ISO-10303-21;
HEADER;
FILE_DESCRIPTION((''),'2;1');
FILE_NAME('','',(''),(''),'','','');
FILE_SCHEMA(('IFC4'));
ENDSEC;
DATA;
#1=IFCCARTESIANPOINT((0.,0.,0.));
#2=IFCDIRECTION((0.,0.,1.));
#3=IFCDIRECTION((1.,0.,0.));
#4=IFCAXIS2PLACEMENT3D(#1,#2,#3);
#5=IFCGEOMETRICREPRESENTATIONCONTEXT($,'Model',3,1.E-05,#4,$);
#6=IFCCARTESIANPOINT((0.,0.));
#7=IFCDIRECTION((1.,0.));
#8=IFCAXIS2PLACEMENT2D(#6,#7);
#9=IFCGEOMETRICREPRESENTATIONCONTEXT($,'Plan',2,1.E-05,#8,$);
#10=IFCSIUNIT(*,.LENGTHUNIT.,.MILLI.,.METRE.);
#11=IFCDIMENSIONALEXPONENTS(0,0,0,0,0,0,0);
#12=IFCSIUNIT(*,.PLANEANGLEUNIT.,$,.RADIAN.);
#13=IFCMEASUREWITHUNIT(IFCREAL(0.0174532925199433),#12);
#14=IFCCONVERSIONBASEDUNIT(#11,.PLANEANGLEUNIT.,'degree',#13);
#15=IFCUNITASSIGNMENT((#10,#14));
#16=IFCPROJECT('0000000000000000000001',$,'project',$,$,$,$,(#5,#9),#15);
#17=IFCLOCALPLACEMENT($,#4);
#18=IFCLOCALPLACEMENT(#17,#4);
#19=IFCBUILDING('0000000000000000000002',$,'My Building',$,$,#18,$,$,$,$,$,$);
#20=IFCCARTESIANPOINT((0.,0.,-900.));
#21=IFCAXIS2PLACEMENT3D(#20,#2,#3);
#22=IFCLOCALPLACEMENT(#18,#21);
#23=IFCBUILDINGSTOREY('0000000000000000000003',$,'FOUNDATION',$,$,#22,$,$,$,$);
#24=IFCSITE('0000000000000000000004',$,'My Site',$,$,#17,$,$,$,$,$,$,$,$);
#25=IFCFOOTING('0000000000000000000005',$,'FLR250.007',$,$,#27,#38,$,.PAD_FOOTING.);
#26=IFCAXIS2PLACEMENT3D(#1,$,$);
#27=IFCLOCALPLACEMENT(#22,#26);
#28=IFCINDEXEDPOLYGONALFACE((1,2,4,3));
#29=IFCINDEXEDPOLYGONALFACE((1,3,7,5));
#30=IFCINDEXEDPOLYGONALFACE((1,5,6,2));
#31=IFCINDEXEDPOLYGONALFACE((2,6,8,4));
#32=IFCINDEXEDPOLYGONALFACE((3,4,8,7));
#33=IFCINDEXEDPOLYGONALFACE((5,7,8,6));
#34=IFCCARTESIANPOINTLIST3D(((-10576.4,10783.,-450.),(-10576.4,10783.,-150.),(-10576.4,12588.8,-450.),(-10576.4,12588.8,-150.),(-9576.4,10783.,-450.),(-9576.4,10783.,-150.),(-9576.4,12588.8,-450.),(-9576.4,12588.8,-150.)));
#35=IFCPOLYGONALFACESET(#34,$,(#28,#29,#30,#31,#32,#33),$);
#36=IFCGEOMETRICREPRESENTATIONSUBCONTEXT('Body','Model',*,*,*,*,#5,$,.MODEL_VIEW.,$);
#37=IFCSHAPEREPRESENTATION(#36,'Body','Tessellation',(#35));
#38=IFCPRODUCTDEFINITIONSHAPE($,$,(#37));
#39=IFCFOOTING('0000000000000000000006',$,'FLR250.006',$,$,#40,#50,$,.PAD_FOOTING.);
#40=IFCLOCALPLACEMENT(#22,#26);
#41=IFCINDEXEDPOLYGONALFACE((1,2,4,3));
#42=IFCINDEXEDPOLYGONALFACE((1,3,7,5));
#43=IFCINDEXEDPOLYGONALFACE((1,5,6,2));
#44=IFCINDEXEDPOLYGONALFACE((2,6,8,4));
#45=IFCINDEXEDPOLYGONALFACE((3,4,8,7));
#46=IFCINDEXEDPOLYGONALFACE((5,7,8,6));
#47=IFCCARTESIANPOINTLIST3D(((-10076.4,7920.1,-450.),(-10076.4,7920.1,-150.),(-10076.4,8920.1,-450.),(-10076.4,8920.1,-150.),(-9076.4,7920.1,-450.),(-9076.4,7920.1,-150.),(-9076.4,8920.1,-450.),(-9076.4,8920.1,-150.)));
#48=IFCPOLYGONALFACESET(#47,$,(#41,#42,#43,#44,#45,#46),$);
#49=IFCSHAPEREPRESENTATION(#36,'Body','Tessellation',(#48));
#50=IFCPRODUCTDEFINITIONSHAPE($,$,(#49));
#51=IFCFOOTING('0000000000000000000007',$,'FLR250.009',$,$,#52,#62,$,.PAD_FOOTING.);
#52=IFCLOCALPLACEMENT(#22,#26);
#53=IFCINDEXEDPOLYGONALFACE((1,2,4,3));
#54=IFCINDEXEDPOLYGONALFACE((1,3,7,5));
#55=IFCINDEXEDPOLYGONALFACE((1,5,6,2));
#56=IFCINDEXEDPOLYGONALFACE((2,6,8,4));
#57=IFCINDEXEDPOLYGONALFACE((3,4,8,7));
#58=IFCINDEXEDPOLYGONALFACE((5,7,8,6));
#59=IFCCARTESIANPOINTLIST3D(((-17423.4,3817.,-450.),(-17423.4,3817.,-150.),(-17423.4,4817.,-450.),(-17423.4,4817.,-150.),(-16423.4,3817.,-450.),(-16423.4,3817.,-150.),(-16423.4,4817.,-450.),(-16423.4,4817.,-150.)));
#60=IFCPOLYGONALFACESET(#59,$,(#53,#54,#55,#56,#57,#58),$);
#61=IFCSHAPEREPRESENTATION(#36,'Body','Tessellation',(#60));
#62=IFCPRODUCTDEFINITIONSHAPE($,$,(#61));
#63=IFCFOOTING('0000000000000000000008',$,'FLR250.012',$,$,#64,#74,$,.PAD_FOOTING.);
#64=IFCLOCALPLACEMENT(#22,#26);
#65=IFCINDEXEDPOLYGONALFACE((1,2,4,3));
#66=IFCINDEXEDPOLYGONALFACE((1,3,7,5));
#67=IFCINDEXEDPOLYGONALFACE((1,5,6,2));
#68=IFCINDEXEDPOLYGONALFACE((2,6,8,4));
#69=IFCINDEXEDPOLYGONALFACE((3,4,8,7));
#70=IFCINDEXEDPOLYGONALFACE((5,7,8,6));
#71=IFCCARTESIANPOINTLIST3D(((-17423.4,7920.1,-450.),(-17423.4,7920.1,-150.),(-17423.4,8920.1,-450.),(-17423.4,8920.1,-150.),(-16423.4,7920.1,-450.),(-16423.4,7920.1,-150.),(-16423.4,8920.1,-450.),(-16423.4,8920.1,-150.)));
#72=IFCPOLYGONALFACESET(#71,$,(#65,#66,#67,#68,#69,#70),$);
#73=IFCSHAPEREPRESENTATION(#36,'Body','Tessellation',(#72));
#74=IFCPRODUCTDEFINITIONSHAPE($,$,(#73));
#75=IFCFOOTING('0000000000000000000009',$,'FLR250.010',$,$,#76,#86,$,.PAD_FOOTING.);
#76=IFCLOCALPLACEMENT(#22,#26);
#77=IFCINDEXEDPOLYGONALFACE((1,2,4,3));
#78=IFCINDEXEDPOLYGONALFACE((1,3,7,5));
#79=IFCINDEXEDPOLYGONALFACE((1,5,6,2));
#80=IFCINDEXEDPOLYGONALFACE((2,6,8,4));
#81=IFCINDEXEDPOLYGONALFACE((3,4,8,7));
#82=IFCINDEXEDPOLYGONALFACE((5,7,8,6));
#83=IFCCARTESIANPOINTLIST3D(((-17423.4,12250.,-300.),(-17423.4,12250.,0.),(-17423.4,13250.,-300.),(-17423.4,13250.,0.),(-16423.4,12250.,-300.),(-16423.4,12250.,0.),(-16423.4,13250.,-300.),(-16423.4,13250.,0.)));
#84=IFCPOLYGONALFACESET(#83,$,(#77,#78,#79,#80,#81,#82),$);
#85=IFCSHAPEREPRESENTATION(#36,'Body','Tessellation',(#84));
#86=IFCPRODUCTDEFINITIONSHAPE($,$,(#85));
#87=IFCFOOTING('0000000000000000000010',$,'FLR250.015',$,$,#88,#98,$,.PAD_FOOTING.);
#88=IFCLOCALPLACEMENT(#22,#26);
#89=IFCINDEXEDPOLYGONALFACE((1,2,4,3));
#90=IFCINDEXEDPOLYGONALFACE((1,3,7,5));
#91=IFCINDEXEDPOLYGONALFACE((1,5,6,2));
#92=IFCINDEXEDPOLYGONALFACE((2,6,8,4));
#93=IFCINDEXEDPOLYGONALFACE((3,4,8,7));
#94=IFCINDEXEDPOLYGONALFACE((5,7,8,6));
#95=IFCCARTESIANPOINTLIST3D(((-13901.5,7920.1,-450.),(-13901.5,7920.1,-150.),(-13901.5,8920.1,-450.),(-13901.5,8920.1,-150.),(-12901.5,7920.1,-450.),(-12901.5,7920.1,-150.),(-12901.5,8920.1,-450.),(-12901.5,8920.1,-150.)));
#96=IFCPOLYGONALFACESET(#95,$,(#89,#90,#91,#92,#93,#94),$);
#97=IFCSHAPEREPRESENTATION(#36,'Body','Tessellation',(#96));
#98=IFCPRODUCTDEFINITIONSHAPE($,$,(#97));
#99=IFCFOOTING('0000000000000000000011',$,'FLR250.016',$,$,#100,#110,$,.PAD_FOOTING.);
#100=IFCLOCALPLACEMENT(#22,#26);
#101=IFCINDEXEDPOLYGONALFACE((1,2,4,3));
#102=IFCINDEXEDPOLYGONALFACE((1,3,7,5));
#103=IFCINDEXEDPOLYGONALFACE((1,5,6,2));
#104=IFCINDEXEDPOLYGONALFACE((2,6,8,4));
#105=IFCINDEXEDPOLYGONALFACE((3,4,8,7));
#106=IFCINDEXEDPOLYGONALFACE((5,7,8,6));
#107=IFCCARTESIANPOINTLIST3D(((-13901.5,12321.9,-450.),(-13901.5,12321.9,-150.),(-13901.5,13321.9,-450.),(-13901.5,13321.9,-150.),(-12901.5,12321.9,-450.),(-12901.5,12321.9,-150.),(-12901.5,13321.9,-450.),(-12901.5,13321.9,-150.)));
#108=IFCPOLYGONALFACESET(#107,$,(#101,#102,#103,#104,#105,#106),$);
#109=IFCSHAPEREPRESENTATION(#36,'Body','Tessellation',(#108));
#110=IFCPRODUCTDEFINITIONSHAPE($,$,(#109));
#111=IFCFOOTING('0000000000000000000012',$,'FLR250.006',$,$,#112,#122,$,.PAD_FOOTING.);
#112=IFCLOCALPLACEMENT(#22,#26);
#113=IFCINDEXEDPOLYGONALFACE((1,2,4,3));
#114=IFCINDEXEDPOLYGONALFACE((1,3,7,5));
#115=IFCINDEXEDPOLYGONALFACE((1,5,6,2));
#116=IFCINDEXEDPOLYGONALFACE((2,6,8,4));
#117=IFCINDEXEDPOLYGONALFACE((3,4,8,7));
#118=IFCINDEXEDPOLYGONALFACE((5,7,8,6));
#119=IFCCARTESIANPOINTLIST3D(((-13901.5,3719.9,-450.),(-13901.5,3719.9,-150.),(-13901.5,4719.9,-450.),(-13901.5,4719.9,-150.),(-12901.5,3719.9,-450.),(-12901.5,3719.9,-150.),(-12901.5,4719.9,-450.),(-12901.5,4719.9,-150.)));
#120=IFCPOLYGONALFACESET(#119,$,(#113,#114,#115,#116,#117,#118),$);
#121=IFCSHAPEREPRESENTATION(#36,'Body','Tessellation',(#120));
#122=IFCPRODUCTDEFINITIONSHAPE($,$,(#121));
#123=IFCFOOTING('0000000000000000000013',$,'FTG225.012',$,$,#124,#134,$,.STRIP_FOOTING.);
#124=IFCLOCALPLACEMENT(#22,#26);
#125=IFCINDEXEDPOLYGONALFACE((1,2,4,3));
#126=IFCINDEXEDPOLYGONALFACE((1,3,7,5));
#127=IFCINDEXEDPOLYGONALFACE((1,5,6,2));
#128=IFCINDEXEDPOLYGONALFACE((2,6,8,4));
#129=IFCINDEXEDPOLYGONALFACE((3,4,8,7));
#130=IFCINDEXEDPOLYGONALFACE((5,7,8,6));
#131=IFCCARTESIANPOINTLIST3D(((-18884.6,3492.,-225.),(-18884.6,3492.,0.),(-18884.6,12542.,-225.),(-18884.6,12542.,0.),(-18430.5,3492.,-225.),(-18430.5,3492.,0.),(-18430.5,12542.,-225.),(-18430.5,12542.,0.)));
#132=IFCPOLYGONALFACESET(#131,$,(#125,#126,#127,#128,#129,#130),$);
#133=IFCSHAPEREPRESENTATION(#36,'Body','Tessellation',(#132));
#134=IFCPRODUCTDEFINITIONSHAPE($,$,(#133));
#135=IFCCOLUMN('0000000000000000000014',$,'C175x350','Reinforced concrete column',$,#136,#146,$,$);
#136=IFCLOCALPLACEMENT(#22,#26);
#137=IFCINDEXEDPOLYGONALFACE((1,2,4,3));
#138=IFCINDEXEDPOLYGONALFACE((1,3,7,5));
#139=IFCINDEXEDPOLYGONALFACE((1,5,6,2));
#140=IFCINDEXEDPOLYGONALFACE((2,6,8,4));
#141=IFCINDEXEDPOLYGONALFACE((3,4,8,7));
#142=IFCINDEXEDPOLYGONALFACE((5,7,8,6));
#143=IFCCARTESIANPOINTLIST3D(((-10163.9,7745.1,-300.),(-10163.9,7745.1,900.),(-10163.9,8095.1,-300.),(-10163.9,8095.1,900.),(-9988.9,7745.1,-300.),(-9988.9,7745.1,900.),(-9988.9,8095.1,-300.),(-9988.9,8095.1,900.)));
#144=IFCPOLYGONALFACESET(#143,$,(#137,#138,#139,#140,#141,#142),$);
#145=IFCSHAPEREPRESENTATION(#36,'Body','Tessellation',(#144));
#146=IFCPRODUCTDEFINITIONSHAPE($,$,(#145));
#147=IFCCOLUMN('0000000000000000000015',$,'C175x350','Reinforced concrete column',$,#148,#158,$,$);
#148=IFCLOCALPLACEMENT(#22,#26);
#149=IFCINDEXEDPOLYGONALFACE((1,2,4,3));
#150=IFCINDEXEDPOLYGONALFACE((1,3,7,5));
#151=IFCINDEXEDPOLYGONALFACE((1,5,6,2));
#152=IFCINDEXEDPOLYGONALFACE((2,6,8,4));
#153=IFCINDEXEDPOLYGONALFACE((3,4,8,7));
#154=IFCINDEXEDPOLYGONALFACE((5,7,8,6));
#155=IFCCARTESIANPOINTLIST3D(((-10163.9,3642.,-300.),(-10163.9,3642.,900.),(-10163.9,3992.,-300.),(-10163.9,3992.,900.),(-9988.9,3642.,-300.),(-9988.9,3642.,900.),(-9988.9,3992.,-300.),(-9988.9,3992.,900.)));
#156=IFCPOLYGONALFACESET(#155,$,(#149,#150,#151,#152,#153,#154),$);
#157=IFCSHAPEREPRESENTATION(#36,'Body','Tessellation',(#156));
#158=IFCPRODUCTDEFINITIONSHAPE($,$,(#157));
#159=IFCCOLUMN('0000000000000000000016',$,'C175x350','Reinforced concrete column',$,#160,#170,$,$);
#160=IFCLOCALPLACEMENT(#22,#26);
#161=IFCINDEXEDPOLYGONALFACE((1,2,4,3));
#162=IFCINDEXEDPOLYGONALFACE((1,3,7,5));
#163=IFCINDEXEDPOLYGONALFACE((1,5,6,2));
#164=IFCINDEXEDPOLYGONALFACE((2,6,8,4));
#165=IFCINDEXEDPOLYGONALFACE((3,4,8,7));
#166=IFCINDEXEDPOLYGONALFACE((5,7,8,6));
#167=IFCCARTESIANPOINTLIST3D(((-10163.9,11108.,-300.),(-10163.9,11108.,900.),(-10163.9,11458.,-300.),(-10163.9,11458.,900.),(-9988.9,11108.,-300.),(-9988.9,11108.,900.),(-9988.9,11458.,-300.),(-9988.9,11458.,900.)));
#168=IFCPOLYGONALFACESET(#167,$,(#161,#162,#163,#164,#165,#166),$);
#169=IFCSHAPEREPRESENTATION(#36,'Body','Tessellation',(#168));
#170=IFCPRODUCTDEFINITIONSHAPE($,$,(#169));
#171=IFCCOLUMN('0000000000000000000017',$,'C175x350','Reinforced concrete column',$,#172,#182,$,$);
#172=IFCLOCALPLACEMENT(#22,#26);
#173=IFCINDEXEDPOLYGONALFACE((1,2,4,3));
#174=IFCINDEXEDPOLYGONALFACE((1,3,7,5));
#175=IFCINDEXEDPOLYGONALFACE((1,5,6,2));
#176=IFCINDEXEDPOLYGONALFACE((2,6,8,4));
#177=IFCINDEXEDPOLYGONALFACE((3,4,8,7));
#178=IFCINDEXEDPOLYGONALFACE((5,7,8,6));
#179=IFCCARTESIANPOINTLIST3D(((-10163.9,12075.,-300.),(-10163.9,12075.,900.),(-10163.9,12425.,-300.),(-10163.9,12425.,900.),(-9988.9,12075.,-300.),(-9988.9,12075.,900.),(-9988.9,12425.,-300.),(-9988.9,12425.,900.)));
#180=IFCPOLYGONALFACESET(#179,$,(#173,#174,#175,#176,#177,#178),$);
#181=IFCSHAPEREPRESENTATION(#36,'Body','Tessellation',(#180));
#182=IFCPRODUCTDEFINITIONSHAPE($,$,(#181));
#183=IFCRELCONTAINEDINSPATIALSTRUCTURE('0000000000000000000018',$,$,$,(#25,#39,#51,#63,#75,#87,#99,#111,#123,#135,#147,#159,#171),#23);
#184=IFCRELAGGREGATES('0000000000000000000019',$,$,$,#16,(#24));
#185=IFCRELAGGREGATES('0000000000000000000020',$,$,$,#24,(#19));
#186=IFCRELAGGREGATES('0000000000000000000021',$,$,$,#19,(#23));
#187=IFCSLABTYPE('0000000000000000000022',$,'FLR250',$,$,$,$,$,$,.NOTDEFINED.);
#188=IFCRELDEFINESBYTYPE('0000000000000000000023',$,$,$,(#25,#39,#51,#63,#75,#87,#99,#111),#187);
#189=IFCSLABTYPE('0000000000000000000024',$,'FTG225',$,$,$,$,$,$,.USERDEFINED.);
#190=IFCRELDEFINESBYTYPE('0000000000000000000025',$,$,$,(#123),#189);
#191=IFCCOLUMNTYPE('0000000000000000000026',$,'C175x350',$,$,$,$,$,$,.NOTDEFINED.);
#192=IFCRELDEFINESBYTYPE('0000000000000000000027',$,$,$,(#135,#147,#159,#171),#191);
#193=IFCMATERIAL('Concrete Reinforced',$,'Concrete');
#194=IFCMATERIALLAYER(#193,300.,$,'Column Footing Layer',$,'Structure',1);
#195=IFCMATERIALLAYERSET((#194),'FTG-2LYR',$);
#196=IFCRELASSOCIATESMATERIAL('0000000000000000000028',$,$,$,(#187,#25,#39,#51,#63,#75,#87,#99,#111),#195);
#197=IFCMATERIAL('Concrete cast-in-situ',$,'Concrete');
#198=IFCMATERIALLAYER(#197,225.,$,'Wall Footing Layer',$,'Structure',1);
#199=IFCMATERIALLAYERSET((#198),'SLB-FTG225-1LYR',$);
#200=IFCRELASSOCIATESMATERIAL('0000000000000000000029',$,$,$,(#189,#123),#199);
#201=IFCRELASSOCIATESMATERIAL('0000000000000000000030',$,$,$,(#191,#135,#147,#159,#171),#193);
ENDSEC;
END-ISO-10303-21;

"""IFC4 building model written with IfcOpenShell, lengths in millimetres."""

from ifc_helpers import new_model, entity, si_unit, converted_unit, frame, origin_with_axes, origin_2d_with_axis, place, context, subcontext, project, spatial, line, indexed_curve, rectangle, outline, extrude, material, layer, layer_set, layer_usage, material_profile, profile_set, profile_usage, type_object, element, save


model = new_model("IFC4")

# Units and contexts
model_context = context("Model", 3, precision=1e-05, world=origin_with_axes())
plan_context = context("Plan", 2, precision=1e-05, world=origin_2d_with_axis())
body_context = subcontext(model_context, "Body", "Model", "MODEL_VIEW")
ifc_project = project(units=[si_unit("LENGTHUNIT", "METRE", prefix="MILLI"), converted_unit("PLANEANGLEUNIT", "degree", entity("IfcReal", 0.0174532925199433), si_unit("PLANEANGLEUNIT", "RADIAN"), dimensions=[0, 0, 0, 0, 0, 0, 0])], contexts=[model_context, plan_context])

# Site, building, storey
site_placement = place(None, origin_with_axes())
site = spatial("IfcSite", under=ifc_project, at=site_placement, Name="My Site")
building_placement = place(site_placement, origin_with_axes())
building = spatial("IfcBuilding", under=site, at=building_placement, Name="My Building")
storey_placement = place(building_placement, frame((0.0, 0.0, -900.0), z_axis=(0.0, 0.0, 1.0), x_axis=(1.0, 0.0, 0.0)))
storey = spatial("IfcBuildingStorey", under=building, at=storey_placement, Name="FOUNDATION")

# Footings
ifc_material_1 = material(Name="Concrete Reinforced", Category="Concrete")
ifc_layer_1 = layer(ifc_material_1, 300.0, Name="Column Footing Layer", Category="Structure", Priority=1)
ifc_layer_set_1 = layer_set([ifc_layer_1], Name="FTG-2LYR")
ifc_layer_usage_1 = layer_usage(ifc_layer_set_1, "AXIS3", "POSITIVE", 0.0)
slab_type_1 = type_object("IfcSlabType", Name="FLR250", PredefinedType="NOTDEFINED", material=ifc_layer_set_1)
footing_1_placement = place(storey_placement, frame((-10076.4, 11283.0, -450.0), z_axis=(0.0, 0.0, 1.0), x_axis=(1.0, 0.0, 0.0)))
element("IfcFooting", 1, at=footing_1_placement, inside=storey, type_object=slab_type_1, material=ifc_layer_usage_1, Name="FLR250.007", PredefinedType="PAD_FOOTING", context=body_context, shape_type="SweptSolid", body=[
    extrude(outline(indexed_curve([(500.0, 1305.8), (500.0, -500.0), (-500.0, -500.0), (-500.0, 1305.8)], segments=[line(3, 2), line(2, 1), line(1, 4), line(4, 3)], self_intersect=False)), None, (0.0, 0.0, 1.0), 300.0),
])
ifc_layer_usage_2 = layer_usage(ifc_layer_set_1, "AXIS3", "POSITIVE", 0.0)
footing_2_placement = place(storey_placement, frame((-10076.4, 7920.1, -450.0), z_axis=(0.0, 0.0, 1.0), x_axis=(1.0, 0.0, 0.0)))
element("IfcFooting", 2, at=footing_2_placement, inside=storey, type_object=slab_type_1, material=ifc_layer_usage_2, Name="FLR250.006", PredefinedType="PAD_FOOTING", context=body_context, shape_type="SweptSolid", body=[
    extrude(outline(indexed_curve([(0.0, 0.0), (1000.0, 0.0), (1000.0, 1000.0), (0.0, 1000.0), (0.0, 0.0)])), None, (0.0, 0.0, 1.0), 300.0),
])
ifc_layer_usage_3 = layer_usage(ifc_layer_set_1, "AXIS3", "POSITIVE", 0.0)
footing_3_placement = place(storey_placement, frame((-17423.4, 3817.0, -450.0), z_axis=(0.0, 0.0, 1.0), x_axis=(1.0, 0.0, 0.0)))
element("IfcFooting", 3, at=footing_3_placement, inside=storey, type_object=slab_type_1, material=ifc_layer_usage_3, Name="FLR250.009", PredefinedType="PAD_FOOTING", context=body_context, shape_type="SweptSolid", body=[
    extrude(outline(indexed_curve([(0.0, 0.0), (1000.0, 0.0), (1000.0, 1000.0), (0.0, 1000.0), (0.0, 0.0)])), None, (0.0, 0.0, 1.0), 300.0),
])
ifc_layer_usage_4 = layer_usage(ifc_layer_set_1, "AXIS3", "POSITIVE", 0.0)
footing_4_placement = place(storey_placement, frame((-17423.4, 7920.1, -450.0), z_axis=(0.0, 0.0, 1.0), x_axis=(1.0, 0.0, 0.0)))
element("IfcFooting", 4, at=footing_4_placement, inside=storey, type_object=slab_type_1, material=ifc_layer_usage_4, Name="FLR250.012", PredefinedType="PAD_FOOTING", context=body_context, shape_type="SweptSolid", body=[
    extrude(outline(indexed_curve([(0.0, 0.0), (1000.0, 0.0), (1000.0, 1000.0), (0.0, 1000.0), (0.0, 0.0)])), None, (0.0, 0.0, 1.0), 300.0),
])
ifc_layer_usage_5 = layer_usage(ifc_layer_set_1, "AXIS3", "POSITIVE", 0.0)
footing_5_placement = place(storey_placement, frame((-17423.4, 12250.0, -300.0), z_axis=(0.0, 0.0, 1.0), x_axis=(1.0, 0.0, 0.0)))
element("IfcFooting", 5, at=footing_5_placement, inside=storey, type_object=slab_type_1, material=ifc_layer_usage_5, Name="FLR250.010", PredefinedType="PAD_FOOTING", context=body_context, shape_type="SweptSolid", body=[
    extrude(outline(indexed_curve([(0.0, 0.0), (1000.0, 0.0), (1000.0, 1000.0), (0.0, 1000.0), (0.0, 0.0)])), None, (0.0, 0.0, 1.0), 300.0),
])
ifc_layer_usage_6 = layer_usage(ifc_layer_set_1, "AXIS3", "POSITIVE", 0.0)
footing_6_placement = place(storey_placement, frame((-13901.5, 7920.1, -450.0), z_axis=(0.0, 0.0, 1.0), x_axis=(1.0, 0.0, 0.0)))
element("IfcFooting", 6, at=footing_6_placement, inside=storey, type_object=slab_type_1, material=ifc_layer_usage_6, Name="FLR250.015", PredefinedType="PAD_FOOTING", context=body_context, shape_type="SweptSolid", body=[
    extrude(outline(indexed_curve([(0.0, 0.0), (1000.0, 0.0), (1000.0, 1000.0), (0.0, 1000.0), (0.0, 0.0)])), None, (0.0, 0.0, 1.0), 300.0),
])
ifc_layer_usage_7 = layer_usage(ifc_layer_set_1, "AXIS3", "POSITIVE", 0.0)
footing_7_placement = place(storey_placement, frame((-13901.5, 12321.9, -450.0), z_axis=(0.0, 0.0, 1.0), x_axis=(1.0, 0.0, 0.0)))
element("IfcFooting", 7, at=footing_7_placement, inside=storey, type_object=slab_type_1, material=ifc_layer_usage_7, Name="FLR250.016", PredefinedType="PAD_FOOTING", context=body_context, shape_type="SweptSolid", body=[
    extrude(outline(indexed_curve([(0.0, 0.0), (1000.0, 0.0), (1000.0, 1000.0), (0.0, 1000.0), (0.0, 0.0)])), None, (0.0, 0.0, 1.0), 300.0),
])
ifc_layer_usage_8 = layer_usage(ifc_layer_set_1, "AXIS3", "POSITIVE", 0.0)
footing_8_placement = place(storey_placement, frame((-13901.5, 3719.9, -450.0), z_axis=(0.0, 0.0, 1.0), x_axis=(1.0, 0.0, 0.0)))
element("IfcFooting", 8, at=footing_8_placement, inside=storey, type_object=slab_type_1, material=ifc_layer_usage_8, Name="FLR250.006", PredefinedType="PAD_FOOTING", context=body_context, shape_type="SweptSolid", body=[
    extrude(outline(indexed_curve([(0.0, 0.0), (1000.0, 0.0), (1000.0, 1000.0), (0.0, 1000.0), (0.0, 0.0)])), None, (0.0, 0.0, 1.0), 300.0),
])
ifc_material_2 = material(Name="Concrete cast-in-situ", Category="Concrete")
ifc_layer_2 = layer(ifc_material_2, 225.0, Name="Wall Footing Layer", Category="Structure", Priority=1)
ifc_layer_set_2 = layer_set([ifc_layer_2], Name="SLB-FTG225-1LYR")
slab_type_2 = type_object("IfcSlabType", Name="FTG225", PredefinedType="USERDEFINED", material=ifc_layer_set_2)
ifc_layer_usage_9 = layer_usage(ifc_layer_set_2, "AXIS3", "POSITIVE", 0.0)
footing_9_placement = place(storey_placement, frame((-18884.6, 3492.0, -225.0), z_axis=(0.0, 0.0, 1.0), x_axis=(1.0, 0.0, 0.0)))
element("IfcFooting", 9, at=footing_9_placement, inside=storey, type_object=slab_type_2, material=ifc_layer_usage_9, Name="FTG225.012", PredefinedType="STRIP_FOOTING", context=body_context, shape_type="SweptSolid", body=[
    extrude(outline(indexed_curve([(454.1, 9050.0), (454.1, 0.0), (0.0, 0.0), (0.0, 9050.0)], segments=[line(3, 2), line(2, 1), line(1, 4), line(4, 3)], self_intersect=False)), None, (0.0, 0.0, 1.0), 225.0),
])

# Columns
ifc_material_profile = material_profile(ifc_material_1, rectangle(XDim=175.0, YDim=350.0), Name="R. C. Layer", Category="Structure", Priority=1)
ifc_profile_set = profile_set([ifc_material_profile], Name="COL_1LYR")
ifc_profile_usage_1 = profile_usage(ifc_profile_set, cardinal=5)
column_type = type_object("IfcColumnType", Name="C175x350", PredefinedType="NOTDEFINED", material=ifc_profile_set)
column_1_placement = place(storey_placement, frame((-10076.4, 7920.1, -300.0), z_axis=(0.0, 0.0, 1.0), x_axis=(1.0, 0.0, 0.0)))
element("IfcColumn", 10, at=column_1_placement, inside=storey, type_object=column_type, material=ifc_profile_usage_1, Name="C175x350", Description="Reinforced concrete column", context=body_context, shape_type="SweptSolid", body=[
    extrude(rectangle(XDim=175.0, YDim=350.0), origin_with_axes(), (0.0, 0.0, 1.0), 1200.0),
])
ifc_profile_usage_2 = profile_usage(ifc_profile_set, cardinal=5)
column_2_placement = place(storey_placement, frame((-10076.4, 3817.0, -300.0), z_axis=(0.0, 0.0, 1.0), x_axis=(1.0, 0.0, 0.0)))
element("IfcColumn", 11, at=column_2_placement, inside=storey, type_object=column_type, material=ifc_profile_usage_2, Name="C175x350", Description="Reinforced concrete column", context=body_context, shape_type="SweptSolid", body=[
    extrude(rectangle(XDim=175.0, YDim=350.0), origin_with_axes(), (0.0, 0.0, 1.0), 1200.0),
])
ifc_profile_usage_3 = profile_usage(ifc_profile_set, cardinal=5)
column_3_placement = place(storey_placement, frame((-10076.4, 11283.0, -300.0), z_axis=(0.0, 0.0, 1.0), x_axis=(1.0, 0.0, 0.0)))
element("IfcColumn", 12, at=column_3_placement, inside=storey, type_object=column_type, material=ifc_profile_usage_3, Name="C175x350", Description="Reinforced concrete column", context=body_context, shape_type="SweptSolid", body=[
    extrude(rectangle(XDim=175.0, YDim=350.0), origin_with_axes(), (0.0, 0.0, 1.0), 1200.0),
])
ifc_profile_usage_4 = profile_usage(ifc_profile_set, cardinal=5)
column_4_placement = place(storey_placement, frame((-10076.4, 12250.0, -300.0), z_axis=(0.0, 0.0, 1.0), x_axis=(1.0, 0.0, 0.0)))
element("IfcColumn", 13, at=column_4_placement, inside=storey, type_object=column_type, material=ifc_profile_usage_4, Name="C175x350", Description="Reinforced concrete column", context=body_context, shape_type="SweptSolid", body=[
    extrude(rectangle(XDim=175.0, YDim=350.0), origin_with_axes(), (0.0, 0.0, 1.0), 1200.0),
])

save(model, "model.ifc")
